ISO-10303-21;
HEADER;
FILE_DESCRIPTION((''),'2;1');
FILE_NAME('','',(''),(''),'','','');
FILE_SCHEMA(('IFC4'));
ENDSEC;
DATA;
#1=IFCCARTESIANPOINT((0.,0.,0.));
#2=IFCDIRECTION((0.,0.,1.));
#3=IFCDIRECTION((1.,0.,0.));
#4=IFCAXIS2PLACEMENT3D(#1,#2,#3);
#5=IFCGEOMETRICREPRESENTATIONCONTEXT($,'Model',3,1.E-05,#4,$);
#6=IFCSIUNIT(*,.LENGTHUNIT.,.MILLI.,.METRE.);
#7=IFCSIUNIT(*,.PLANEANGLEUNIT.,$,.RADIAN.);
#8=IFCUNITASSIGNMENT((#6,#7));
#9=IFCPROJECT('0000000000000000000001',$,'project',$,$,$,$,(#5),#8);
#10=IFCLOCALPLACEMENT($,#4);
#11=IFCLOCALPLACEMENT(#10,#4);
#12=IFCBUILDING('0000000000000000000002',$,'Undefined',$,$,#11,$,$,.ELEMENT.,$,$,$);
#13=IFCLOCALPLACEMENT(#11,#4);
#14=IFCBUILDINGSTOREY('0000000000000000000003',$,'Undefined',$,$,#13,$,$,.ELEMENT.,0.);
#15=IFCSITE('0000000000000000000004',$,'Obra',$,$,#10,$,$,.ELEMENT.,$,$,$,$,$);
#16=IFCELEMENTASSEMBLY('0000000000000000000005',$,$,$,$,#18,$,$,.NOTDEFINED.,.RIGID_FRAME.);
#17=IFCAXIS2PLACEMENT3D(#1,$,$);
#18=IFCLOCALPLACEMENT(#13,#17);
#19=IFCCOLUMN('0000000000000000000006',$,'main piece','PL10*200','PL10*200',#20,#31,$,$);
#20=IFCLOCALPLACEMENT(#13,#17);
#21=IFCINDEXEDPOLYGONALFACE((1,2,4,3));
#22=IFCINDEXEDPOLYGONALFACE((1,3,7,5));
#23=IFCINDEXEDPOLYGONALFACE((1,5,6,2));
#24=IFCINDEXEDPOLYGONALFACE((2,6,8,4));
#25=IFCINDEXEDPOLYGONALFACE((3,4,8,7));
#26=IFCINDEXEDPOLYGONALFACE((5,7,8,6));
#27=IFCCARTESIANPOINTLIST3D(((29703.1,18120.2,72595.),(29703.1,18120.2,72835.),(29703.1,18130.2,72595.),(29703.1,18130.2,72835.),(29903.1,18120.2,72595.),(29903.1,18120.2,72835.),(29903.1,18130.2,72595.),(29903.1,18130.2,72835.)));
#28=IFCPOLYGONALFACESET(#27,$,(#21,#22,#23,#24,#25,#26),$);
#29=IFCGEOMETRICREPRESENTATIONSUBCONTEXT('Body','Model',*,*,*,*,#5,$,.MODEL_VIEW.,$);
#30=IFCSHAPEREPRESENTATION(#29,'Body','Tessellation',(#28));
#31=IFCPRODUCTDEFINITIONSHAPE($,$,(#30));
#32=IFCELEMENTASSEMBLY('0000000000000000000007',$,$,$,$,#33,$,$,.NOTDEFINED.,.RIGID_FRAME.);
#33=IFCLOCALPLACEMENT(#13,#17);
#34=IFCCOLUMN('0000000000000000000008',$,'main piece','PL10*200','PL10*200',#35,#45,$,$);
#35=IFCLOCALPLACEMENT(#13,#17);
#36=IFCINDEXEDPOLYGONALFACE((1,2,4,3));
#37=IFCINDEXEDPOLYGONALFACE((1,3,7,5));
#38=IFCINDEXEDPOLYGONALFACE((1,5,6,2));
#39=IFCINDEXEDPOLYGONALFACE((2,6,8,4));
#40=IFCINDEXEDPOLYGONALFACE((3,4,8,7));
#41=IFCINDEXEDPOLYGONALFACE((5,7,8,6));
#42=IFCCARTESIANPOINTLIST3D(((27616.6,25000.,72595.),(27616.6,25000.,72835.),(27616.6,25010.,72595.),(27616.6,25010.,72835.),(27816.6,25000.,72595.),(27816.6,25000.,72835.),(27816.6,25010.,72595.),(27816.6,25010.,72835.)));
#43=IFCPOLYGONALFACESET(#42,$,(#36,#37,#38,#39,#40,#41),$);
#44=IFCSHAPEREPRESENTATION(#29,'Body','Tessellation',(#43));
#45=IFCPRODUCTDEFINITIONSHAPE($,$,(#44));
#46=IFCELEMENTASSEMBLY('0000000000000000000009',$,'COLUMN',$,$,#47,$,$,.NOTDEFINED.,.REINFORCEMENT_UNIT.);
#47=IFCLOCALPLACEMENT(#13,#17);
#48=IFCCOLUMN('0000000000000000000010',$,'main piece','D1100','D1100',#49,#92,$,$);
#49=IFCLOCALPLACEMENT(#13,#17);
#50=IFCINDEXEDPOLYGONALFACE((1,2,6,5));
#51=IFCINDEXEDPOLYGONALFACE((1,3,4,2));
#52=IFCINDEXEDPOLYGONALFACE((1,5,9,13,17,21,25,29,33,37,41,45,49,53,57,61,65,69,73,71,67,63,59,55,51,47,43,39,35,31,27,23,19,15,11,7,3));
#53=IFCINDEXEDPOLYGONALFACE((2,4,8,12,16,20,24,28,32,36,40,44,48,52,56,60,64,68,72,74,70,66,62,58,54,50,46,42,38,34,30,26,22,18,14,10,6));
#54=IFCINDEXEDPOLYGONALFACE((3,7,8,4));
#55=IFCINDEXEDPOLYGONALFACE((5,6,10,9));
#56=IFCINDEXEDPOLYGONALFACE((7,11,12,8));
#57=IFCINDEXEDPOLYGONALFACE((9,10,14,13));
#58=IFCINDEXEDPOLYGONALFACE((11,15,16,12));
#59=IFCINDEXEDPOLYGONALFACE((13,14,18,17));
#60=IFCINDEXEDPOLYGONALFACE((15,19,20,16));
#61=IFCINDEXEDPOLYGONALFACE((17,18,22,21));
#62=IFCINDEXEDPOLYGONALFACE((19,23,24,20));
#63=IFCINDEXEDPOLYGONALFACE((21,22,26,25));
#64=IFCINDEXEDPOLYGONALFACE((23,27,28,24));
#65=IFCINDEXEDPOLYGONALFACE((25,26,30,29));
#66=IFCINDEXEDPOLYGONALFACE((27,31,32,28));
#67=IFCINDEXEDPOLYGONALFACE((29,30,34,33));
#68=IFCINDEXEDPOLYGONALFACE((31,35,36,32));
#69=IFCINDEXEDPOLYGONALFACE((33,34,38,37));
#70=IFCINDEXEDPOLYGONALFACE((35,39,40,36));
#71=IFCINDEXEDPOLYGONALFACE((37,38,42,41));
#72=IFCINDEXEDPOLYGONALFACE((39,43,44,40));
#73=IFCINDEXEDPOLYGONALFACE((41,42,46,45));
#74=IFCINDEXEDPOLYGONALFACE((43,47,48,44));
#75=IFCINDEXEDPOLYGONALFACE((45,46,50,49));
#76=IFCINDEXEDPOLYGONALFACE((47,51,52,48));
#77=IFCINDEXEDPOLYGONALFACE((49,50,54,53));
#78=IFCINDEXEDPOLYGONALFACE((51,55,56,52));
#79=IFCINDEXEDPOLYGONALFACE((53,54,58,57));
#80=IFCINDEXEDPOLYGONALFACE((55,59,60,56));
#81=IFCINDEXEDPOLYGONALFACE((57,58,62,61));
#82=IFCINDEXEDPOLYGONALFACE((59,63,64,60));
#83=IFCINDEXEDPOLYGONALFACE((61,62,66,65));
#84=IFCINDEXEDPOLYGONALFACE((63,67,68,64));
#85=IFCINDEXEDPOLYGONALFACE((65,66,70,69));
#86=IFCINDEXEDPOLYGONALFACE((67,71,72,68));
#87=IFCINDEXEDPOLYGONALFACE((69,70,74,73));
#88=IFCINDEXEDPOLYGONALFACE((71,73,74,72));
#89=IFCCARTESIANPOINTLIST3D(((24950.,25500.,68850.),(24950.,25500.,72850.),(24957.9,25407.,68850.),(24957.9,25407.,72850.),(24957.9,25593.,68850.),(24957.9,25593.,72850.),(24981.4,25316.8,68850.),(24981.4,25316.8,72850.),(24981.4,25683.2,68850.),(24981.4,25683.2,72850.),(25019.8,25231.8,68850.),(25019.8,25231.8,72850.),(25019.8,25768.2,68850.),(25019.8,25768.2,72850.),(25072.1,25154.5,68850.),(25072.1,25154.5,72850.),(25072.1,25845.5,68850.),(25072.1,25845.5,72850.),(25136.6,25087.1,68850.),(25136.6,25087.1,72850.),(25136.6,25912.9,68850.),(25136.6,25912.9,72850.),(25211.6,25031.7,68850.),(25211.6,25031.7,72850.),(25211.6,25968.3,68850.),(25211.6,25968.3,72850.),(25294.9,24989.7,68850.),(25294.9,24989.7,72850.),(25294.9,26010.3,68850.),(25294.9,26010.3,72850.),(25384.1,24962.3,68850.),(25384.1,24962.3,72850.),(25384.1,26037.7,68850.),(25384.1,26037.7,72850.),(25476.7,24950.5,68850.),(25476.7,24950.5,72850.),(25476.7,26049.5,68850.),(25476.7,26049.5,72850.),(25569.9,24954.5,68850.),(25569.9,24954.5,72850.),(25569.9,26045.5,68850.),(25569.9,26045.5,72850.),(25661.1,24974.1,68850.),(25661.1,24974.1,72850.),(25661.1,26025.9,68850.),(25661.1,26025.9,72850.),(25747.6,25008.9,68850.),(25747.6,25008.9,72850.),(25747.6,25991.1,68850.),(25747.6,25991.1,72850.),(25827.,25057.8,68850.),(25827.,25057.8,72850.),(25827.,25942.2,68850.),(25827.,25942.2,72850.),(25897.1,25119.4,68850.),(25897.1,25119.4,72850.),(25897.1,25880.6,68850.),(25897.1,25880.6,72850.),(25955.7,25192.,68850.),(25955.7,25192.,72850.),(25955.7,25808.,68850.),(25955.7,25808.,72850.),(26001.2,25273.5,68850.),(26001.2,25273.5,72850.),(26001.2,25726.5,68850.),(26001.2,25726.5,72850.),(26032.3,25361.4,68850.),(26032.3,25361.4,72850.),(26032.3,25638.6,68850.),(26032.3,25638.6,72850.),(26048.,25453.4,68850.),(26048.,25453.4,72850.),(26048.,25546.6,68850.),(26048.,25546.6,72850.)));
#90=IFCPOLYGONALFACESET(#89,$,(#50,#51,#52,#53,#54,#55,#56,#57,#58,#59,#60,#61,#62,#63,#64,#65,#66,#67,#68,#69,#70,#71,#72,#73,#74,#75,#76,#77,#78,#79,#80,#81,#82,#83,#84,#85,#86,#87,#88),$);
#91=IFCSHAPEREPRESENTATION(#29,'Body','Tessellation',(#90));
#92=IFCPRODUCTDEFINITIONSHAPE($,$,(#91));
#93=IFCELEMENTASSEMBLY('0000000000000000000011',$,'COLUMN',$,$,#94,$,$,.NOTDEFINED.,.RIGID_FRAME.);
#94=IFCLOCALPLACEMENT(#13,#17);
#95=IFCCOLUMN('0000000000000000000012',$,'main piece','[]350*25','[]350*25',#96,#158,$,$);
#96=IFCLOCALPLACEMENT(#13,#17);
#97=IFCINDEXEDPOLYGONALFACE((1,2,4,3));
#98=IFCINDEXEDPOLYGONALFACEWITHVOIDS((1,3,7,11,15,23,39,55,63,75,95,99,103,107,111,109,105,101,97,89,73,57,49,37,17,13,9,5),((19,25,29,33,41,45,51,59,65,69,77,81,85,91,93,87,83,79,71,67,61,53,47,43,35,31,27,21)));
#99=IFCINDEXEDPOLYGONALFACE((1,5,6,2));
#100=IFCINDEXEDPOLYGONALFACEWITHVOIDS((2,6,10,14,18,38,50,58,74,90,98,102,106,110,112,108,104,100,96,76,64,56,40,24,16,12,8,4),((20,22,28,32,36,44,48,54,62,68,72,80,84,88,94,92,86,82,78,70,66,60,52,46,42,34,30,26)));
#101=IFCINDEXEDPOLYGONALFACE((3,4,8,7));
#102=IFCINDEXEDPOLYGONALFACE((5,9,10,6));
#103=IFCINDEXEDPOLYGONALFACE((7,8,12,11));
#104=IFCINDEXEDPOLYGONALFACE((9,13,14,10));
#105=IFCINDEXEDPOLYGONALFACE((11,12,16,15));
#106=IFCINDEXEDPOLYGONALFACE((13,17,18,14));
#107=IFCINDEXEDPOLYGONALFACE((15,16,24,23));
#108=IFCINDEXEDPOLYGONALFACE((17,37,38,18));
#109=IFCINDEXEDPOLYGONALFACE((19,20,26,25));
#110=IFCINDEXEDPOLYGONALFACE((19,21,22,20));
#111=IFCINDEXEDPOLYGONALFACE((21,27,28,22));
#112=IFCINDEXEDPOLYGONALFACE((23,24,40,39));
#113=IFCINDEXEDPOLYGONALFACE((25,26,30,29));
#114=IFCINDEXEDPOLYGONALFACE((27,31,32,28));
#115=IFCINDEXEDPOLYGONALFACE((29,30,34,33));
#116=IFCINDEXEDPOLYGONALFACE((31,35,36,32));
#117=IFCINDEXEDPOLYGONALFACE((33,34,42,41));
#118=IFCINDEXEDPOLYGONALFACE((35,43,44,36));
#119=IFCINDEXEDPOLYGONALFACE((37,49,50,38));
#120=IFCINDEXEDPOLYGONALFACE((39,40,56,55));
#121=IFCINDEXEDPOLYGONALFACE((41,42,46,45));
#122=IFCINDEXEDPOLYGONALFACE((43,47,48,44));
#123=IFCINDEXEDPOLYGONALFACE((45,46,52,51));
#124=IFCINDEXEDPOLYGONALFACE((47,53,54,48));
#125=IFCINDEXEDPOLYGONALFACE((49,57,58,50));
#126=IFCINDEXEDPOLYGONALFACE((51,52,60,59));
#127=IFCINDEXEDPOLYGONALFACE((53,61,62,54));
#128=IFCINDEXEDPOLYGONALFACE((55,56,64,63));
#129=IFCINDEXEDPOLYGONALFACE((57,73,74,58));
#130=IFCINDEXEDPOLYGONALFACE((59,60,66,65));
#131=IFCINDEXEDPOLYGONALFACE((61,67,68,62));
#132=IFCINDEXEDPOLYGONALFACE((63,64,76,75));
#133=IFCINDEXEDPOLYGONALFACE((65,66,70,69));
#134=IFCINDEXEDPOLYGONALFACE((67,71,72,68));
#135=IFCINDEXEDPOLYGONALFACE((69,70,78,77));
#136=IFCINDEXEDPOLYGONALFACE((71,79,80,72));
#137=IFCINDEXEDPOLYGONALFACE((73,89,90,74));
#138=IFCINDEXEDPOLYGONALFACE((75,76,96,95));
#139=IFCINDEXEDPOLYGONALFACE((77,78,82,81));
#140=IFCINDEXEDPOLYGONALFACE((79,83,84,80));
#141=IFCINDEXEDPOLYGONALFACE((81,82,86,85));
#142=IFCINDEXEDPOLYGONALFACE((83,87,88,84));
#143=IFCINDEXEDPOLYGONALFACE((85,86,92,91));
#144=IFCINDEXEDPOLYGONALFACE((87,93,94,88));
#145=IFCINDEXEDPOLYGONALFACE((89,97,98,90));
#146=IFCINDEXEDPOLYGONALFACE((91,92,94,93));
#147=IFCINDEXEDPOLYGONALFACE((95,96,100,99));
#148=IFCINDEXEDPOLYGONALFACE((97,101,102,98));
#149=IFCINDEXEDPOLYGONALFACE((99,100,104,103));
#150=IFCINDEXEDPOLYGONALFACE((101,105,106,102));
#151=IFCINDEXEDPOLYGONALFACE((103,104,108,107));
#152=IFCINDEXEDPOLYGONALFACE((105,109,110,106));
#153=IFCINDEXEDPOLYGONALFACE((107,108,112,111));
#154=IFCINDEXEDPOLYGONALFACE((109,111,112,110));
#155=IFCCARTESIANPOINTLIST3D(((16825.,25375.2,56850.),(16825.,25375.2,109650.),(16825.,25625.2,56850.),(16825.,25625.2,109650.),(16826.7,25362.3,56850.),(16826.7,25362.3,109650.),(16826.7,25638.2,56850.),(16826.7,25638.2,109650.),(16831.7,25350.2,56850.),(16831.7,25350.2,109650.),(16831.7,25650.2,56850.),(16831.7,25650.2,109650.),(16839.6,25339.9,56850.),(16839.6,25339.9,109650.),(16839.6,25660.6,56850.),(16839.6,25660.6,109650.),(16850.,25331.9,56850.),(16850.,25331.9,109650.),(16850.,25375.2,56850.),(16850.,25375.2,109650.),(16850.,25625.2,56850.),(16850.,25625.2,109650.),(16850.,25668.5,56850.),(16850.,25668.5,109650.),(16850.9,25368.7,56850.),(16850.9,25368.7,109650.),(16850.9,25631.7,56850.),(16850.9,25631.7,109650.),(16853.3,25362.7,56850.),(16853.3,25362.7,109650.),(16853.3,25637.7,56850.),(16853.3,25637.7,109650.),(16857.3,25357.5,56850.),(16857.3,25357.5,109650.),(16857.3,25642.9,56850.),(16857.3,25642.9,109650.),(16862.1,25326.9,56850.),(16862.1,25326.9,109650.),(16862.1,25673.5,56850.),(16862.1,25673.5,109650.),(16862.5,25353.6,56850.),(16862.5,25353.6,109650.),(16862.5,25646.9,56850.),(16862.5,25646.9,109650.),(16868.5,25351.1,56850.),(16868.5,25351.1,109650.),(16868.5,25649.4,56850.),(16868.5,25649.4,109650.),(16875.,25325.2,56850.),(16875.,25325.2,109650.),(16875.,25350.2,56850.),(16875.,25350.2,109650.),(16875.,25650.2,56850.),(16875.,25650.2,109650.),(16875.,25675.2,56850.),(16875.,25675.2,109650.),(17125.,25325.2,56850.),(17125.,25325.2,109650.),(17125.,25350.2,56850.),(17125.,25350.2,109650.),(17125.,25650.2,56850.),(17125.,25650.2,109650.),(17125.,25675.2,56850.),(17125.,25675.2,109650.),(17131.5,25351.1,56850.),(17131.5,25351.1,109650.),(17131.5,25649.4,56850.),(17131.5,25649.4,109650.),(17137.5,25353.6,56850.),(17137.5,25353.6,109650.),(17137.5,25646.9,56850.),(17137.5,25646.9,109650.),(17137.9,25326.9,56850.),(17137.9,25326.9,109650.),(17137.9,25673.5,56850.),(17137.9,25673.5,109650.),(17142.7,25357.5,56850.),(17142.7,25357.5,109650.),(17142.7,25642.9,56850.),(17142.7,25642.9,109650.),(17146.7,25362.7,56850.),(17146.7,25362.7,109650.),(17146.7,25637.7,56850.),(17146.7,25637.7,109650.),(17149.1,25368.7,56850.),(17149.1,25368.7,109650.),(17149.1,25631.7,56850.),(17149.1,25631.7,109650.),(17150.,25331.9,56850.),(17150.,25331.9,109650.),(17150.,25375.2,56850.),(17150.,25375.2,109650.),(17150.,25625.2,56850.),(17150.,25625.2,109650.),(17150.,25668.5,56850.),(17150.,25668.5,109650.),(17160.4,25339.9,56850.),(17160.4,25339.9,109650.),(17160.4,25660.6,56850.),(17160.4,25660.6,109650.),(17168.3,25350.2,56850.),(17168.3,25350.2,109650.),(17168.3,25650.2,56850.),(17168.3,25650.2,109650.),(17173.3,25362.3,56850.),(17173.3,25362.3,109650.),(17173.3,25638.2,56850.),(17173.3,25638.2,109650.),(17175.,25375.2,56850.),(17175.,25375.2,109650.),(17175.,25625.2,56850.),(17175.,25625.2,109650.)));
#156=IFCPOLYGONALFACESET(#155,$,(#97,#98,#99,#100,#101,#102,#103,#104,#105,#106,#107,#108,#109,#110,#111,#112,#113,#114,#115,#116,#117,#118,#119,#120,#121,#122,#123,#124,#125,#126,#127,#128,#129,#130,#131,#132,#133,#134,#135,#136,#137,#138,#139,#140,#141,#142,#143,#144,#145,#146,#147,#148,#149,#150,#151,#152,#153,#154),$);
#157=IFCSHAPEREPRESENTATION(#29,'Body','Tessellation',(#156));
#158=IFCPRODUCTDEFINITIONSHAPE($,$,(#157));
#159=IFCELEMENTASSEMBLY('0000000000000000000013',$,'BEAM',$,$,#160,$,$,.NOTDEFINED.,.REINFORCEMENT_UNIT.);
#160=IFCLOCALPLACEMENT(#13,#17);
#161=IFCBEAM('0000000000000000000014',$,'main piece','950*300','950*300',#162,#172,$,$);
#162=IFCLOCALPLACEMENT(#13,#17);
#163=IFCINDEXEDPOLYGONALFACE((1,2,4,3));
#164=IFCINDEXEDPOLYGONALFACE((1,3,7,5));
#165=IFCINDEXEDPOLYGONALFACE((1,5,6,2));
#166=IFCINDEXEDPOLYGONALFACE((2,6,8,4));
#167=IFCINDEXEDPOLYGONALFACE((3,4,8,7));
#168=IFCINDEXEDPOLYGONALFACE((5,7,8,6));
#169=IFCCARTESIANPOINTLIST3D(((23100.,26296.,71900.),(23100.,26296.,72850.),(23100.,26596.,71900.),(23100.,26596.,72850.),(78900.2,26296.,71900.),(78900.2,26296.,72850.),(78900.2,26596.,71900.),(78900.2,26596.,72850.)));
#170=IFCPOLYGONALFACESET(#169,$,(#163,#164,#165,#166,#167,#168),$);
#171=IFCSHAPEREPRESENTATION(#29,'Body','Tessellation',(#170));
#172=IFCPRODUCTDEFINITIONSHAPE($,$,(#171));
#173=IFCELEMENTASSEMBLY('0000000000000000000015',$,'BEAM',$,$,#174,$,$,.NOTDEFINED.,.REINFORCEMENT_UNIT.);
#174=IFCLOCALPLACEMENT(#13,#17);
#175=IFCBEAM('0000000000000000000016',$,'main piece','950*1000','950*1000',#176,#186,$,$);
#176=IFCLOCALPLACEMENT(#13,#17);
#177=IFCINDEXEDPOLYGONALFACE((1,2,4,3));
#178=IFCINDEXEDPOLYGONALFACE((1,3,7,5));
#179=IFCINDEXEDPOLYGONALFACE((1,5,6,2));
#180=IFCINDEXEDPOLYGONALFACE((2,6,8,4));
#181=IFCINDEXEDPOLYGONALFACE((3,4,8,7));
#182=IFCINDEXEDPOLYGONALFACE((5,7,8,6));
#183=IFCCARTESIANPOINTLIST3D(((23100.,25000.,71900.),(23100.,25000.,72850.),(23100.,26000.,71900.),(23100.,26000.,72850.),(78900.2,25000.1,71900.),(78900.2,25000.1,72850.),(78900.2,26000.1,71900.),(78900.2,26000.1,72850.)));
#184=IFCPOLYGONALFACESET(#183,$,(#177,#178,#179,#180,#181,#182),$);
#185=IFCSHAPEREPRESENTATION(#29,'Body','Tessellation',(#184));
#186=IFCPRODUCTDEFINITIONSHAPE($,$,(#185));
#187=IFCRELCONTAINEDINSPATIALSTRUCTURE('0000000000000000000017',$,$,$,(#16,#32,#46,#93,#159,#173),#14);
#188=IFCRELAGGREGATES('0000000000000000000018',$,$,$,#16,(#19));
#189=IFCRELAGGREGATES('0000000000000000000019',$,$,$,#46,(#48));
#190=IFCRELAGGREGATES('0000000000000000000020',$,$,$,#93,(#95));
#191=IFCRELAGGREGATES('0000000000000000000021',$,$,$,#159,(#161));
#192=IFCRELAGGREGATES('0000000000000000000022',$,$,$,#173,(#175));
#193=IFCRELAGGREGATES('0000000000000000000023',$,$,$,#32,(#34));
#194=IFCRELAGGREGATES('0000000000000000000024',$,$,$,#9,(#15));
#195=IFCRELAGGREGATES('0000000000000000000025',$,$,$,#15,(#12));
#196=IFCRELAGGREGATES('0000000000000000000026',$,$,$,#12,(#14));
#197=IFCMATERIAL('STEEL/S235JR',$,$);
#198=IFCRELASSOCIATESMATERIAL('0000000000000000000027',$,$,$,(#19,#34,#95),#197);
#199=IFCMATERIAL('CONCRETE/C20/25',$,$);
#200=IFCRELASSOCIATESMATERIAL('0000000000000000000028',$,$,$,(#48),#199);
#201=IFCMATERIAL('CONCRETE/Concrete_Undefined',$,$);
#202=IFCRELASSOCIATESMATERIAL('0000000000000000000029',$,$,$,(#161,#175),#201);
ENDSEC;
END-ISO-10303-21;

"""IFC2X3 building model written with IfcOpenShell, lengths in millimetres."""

from ifc_helpers import new_model, si_unit, frame, origin_with_axes, origin_2d_with_axis, place, context, subcontext, project, spatial, rectangle, hollow_rectangle, circle, extrude, material, element, aggregate, save


model = new_model("IFC2X3")

# Units and contexts
model_context = context("Model", 3, precision=1e-05, world=origin_with_axes())
body_context = subcontext(model_context, "Body", "Model", "MODEL_VIEW")
ifc_project = project(units=[si_unit("LENGTHUNIT", "METRE", prefix="MILLI"), si_unit("PLANEANGLEUNIT", "RADIAN")], contexts=[model_context])

# Site, building, storey
site_placement = place(None, origin_with_axes())
site = spatial("IfcSite", under=ifc_project, at=site_placement, Name="Obra", CompositionType="ELEMENT")
building_placement = place(site_placement, origin_with_axes())
building = spatial("IfcBuilding", under=site, at=building_placement, Name="Undefined", CompositionType="ELEMENT")
storey_placement = place(building_placement, origin_with_axes())
storey = spatial("IfcBuildingStorey", under=building, at=storey_placement, Name="Undefined", CompositionType="ELEMENT", Elevation=0.0)

# Element assemblies, columns
assembly_1_placement = place(storey_placement, origin_with_axes())
assembly_1 = element("IfcElementAssembly", 1, at=assembly_1_placement, inside=storey, AssemblyPlace="NOTDEFINED", PredefinedType="RIGID_FRAME")
ifc_material_1 = material(Name="STEEL/S235JR")
column_1_placement = place(assembly_1_placement, frame((29803.1, 18125.2, 72595.0), z_axis=(0.0, 0.0, 1.0), x_axis=(1.0, 0.000002, 0.0)))
column_1 = element("IfcColumn", 2, at=column_1_placement, material=ifc_material_1, Name="main piece", Description="PL10*200", ObjectType="PL10*200", context=body_context, shape_type="SweptSolid", body=[
    extrude(rectangle(XDim=10.0, YDim=200.0, at=origin_2d_with_axis()), frame((0.0, 0.0, 240.0), z_axis=(0.0, 0.0, -1.0), x_axis=(0.0, 1.0, 0.0)), (0.0, 0.0, 1.0), 240.0),
])
aggregate(assembly_1, [column_1])
assembly_2_placement = place(storey_placement, origin_with_axes())
assembly_2 = element("IfcElementAssembly", 3, at=assembly_2_placement, inside=storey, AssemblyPlace="NOTDEFINED", PredefinedType="RIGID_FRAME")
column_2_placement = place(assembly_2_placement, frame((27716.6, 25005.0, 72595.0), z_axis=(0.0, 0.0, 1.0), x_axis=(-1.0, -0.000002, 0.0)))
column_2 = element("IfcColumn", 4, at=column_2_placement, material=ifc_material_1, Name="main piece", Description="PL10*200", ObjectType="PL10*200", context=body_context, shape_type="SweptSolid", body=[
    extrude(rectangle(XDim=10.0, YDim=200.0, at=origin_2d_with_axis()), frame((0.0, 0.0, 240.0), z_axis=(0.0, 0.0, -1.0), x_axis=(0.0, 1.0, 0.0)), (0.0, 0.0, 1.0), 240.0),
])
assembly_3_placement = place(storey_placement, origin_with_axes())
assembly_3 = element("IfcElementAssembly", 5, at=assembly_3_placement, inside=storey, Name="COLUMN", AssemblyPlace="NOTDEFINED", PredefinedType="REINFORCEMENT_UNIT")
ifc_material_2 = material(Name="CONCRETE/C20/25")
column_3_placement = place(assembly_3_placement, frame((25500.0, 25500.0, 68850.0), z_axis=(0.0, 0.0, 1.0), x_axis=(0.0, 1.0, 0.0)))
column_3 = element("IfcColumn", 6, at=column_3_placement, material=ifc_material_2, Name="main piece", Description="D1100", ObjectType="D1100", context=body_context, shape_type="SweptSolid", body=[
    extrude(circle(Radius=550.0, at=origin_2d_with_axis()), frame((0.0, 0.0, 4000.0), z_axis=(0.0, 0.0, -1.0), x_axis=(0.0, 1.0, 0.0)), (0.0, 0.0, 1.0), 4000.0),
])
aggregate(assembly_3, [column_3])
assembly_4_placement = place(storey_placement, origin_with_axes())
assembly_4 = element("IfcElementAssembly", 7, at=assembly_4_placement, inside=storey, Name="COLUMN", AssemblyPlace="NOTDEFINED", PredefinedType="RIGID_FRAME")
column_4_placement = place(assembly_4_placement, frame((17000.0, 25500.2, 56850.0), z_axis=(0.0, 0.0, 1.0), x_axis=(0.0, 1.0, 0.0)))
column_4 = element("IfcColumn", 8, at=column_4_placement, material=ifc_material_1, Name="main piece", Description="[]350*25", ObjectType="[]350*25", context=body_context, shape_type="SweptSolid", body=[
    extrude(hollow_rectangle(XDim=350.0, YDim=350.0, WallThickness=25.0, InnerFilletRadius=25.0, OuterFilletRadius=50.0, at=origin_2d_with_axis()), frame((0.0, 0.0, 52800.0), z_axis=(0.0, 0.0, -1.0), x_axis=(0.0, 1.0, 0.0)), (0.0, 0.0, 1.0), 52800.0),
])
aggregate(assembly_4, [column_4])

# Element assemblies, beams
assembly_5_placement = place(storey_placement, origin_with_axes())
assembly_5 = element("IfcElementAssembly", 9, at=assembly_5_placement, inside=storey, Name="BEAM", AssemblyPlace="NOTDEFINED", PredefinedType="REINFORCEMENT_UNIT")
ifc_material_3 = material(Name="CONCRETE/Concrete_Undefined")
beam_1_placement = place(assembly_5_placement, frame((23100.0, 26446.0, 72375.0), z_axis=(0.0, 0.0, 1.0), x_axis=(1.0, 0.0, 0.0)))
beam_1 = element("IfcBeam", 10, at=beam_1_placement, material=ifc_material_3, Name="main piece", Description="950*300", ObjectType="950*300", context=body_context, shape_type="SweptSolid", body=[
    extrude(rectangle(XDim=300.0, YDim=950.0, at=origin_2d_with_axis()), frame((55800.2, 0.0, 0.0), z_axis=(-1.0, 0.0, 0.0), x_axis=(0.0, -1.0, 0.0)), (0.0, 0.0, 1.0), 55800.2),
])
aggregate(assembly_5, [beam_1])
assembly_6_placement = place(storey_placement, origin_with_axes())
assembly_6 = element("IfcElementAssembly", 11, at=assembly_6_placement, inside=storey, Name="BEAM", AssemblyPlace="NOTDEFINED", PredefinedType="REINFORCEMENT_UNIT")
beam_2_placement = place(assembly_6_placement, frame((23100.0, 25500.0, 72375.0), z_axis=(0.0, 0.0, 1.0), x_axis=(1.0, 0.000002, 0.0)))
beam_2 = element("IfcBeam", 12, at=beam_2_placement, material=ifc_material_3, Name="main piece", Description="950*1000", ObjectType="950*1000", context=body_context, shape_type="SweptSolid", body=[
    extrude(rectangle(XDim=1000.0, YDim=950.0, at=origin_2d_with_axis()), frame((55800.2, 0.0, 0.0), z_axis=(-1.0, 0.0, 0.0), x_axis=(0.0, -1.0, 0.0)), (0.0, 0.0, 1.0), 55800.2),
])
aggregate(assembly_6, [beam_2])

aggregate(assembly_2, [column_2])

save(model, "model.ifc")
